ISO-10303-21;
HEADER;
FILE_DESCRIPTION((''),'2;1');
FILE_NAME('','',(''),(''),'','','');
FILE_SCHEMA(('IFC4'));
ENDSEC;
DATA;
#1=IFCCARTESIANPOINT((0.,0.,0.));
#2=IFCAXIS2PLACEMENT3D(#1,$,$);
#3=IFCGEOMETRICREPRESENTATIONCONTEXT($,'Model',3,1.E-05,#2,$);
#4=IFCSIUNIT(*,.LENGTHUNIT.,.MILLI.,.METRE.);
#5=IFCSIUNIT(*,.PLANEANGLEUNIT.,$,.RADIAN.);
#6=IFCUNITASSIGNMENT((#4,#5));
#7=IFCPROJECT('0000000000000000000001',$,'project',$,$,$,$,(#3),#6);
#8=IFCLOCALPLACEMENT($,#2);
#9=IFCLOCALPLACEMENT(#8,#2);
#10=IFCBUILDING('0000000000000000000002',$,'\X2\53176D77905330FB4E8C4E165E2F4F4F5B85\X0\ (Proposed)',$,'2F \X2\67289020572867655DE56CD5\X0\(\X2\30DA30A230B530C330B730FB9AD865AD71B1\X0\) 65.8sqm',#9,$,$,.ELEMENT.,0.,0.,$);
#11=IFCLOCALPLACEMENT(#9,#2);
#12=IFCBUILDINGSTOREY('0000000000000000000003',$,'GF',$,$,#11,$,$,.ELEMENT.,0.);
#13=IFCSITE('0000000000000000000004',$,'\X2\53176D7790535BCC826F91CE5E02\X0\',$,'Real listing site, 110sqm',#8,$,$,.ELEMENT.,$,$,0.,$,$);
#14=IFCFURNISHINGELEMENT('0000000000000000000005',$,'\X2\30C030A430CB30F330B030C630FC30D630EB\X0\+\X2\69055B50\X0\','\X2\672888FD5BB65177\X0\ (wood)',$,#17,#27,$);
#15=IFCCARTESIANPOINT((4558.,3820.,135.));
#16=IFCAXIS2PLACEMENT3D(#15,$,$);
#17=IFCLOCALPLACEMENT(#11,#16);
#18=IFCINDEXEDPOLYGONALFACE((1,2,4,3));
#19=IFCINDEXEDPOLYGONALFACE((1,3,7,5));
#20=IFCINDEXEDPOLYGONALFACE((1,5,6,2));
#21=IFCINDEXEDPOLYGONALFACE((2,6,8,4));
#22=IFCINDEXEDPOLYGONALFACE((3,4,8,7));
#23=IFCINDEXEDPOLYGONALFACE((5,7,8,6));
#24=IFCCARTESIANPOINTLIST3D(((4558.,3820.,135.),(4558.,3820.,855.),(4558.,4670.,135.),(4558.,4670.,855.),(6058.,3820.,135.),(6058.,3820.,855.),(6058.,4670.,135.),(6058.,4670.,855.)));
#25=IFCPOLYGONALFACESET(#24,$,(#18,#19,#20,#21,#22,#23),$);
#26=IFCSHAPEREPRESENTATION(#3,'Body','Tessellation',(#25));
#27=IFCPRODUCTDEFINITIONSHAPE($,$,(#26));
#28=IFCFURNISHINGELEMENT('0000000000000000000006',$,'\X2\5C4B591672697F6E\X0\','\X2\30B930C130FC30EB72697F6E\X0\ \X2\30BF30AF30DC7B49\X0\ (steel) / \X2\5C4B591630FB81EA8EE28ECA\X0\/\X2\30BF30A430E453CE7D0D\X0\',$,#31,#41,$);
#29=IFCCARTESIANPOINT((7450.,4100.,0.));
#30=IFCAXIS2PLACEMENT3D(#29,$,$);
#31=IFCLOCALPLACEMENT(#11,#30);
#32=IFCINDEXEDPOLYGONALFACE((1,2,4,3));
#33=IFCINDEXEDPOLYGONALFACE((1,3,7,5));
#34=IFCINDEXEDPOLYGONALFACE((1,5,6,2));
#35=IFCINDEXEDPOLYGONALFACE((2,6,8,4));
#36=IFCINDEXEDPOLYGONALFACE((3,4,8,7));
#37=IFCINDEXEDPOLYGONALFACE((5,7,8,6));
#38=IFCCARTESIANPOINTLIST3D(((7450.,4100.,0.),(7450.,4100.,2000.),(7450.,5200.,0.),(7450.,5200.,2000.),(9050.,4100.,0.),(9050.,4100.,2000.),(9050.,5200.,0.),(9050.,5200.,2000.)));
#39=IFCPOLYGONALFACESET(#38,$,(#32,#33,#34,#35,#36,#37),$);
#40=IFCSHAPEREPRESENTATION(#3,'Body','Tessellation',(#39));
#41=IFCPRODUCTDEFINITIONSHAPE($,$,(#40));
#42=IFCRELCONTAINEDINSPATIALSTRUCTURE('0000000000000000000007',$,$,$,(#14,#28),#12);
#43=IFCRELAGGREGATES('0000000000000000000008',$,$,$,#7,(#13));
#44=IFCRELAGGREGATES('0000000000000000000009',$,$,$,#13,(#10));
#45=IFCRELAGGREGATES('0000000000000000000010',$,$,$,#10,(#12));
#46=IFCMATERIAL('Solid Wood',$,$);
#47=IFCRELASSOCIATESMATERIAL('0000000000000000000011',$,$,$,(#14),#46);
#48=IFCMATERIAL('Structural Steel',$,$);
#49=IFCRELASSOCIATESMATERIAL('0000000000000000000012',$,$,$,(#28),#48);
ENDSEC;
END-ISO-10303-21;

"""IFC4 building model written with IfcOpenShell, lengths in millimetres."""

from ifc_helpers import new_model, si_unit, frame, frame_2d, origin, place, context, project, spatial, rectangle, extrude, material, element, save


model = new_model("IFC4")

# Units and contexts
model_context = context("Model", 3, precision=1e-05, world=origin())
ifc_project = project(units=[si_unit("LENGTHUNIT", "METRE", prefix="MILLI"), si_unit("PLANEANGLEUNIT", "RADIAN")], contexts=[model_context])

# Site, building, storey
site_placement = place(None, origin())
site = spatial("IfcSite", under=ifc_project, at=site_placement, Name="北海道富良野市", ObjectType="Real listing site, 110sqm", CompositionType="ELEMENT", RefElevation=0.0)
building_placement = place(site_placement, origin())
building = spatial("IfcBuilding", under=site, at=building_placement, Name="北海道・二世帯住宅 (Proposed)", ObjectType="2F 木造在来工法(ペアサッシ・高断熱) 65.8sqm", CompositionType="ELEMENT", ElevationOfRefHeight=0.0, ElevationOfTerrain=0.0)
storey_placement = place(building_placement, origin())
storey = spatial("IfcBuildingStorey", under=building, at=storey_placement, Name="GF", CompositionType="ELEMENT", Elevation=0.0)

# Shared definitions
ifc_material_1 = material(Name="Solid Wood")

# Shared definitions
ifc_material_2 = material(Name="Structural Steel")

# Furnishing elements
furnishing_1_placement = place(storey_placement, frame((4558.0, 3820.0, 135.0)))
element("IfcFurnishingElement", 1, at=furnishing_1_placement, inside=storey, material=ifc_material_1, Name="ダイニングテーブル+椅子", Description="木製家具 (wood)", context=model_context, shape_type="SweptSolid", body=[
    extrude(rectangle(XDim=1500.0, YDim=850.0, at=frame_2d((750.0, 425.0))), frame((4558.0, 3820.0, 135.0)), (0.0, 0.0, 1.0), 720.0),
])
furnishing_2_placement = place(storey_placement, frame((7450.0, 4100.0, 0.0)))
element("IfcFurnishingElement", 2, at=furnishing_2_placement, inside=storey, material=ifc_material_2, Name="屋外物置", Description="スチール物置 タクボ等 (steel) / 屋外・自転車/タイヤ収納", context=model_context, shape_type="SweptSolid", body=[
    extrude(rectangle(XDim=1600.0, YDim=1100.0, at=frame_2d((800.0, 550.0))), frame((7450.0, 4100.0, 0.0)), (0.0, 0.0, 1.0), 2000.0),
])

save(model, "model.ifc")
